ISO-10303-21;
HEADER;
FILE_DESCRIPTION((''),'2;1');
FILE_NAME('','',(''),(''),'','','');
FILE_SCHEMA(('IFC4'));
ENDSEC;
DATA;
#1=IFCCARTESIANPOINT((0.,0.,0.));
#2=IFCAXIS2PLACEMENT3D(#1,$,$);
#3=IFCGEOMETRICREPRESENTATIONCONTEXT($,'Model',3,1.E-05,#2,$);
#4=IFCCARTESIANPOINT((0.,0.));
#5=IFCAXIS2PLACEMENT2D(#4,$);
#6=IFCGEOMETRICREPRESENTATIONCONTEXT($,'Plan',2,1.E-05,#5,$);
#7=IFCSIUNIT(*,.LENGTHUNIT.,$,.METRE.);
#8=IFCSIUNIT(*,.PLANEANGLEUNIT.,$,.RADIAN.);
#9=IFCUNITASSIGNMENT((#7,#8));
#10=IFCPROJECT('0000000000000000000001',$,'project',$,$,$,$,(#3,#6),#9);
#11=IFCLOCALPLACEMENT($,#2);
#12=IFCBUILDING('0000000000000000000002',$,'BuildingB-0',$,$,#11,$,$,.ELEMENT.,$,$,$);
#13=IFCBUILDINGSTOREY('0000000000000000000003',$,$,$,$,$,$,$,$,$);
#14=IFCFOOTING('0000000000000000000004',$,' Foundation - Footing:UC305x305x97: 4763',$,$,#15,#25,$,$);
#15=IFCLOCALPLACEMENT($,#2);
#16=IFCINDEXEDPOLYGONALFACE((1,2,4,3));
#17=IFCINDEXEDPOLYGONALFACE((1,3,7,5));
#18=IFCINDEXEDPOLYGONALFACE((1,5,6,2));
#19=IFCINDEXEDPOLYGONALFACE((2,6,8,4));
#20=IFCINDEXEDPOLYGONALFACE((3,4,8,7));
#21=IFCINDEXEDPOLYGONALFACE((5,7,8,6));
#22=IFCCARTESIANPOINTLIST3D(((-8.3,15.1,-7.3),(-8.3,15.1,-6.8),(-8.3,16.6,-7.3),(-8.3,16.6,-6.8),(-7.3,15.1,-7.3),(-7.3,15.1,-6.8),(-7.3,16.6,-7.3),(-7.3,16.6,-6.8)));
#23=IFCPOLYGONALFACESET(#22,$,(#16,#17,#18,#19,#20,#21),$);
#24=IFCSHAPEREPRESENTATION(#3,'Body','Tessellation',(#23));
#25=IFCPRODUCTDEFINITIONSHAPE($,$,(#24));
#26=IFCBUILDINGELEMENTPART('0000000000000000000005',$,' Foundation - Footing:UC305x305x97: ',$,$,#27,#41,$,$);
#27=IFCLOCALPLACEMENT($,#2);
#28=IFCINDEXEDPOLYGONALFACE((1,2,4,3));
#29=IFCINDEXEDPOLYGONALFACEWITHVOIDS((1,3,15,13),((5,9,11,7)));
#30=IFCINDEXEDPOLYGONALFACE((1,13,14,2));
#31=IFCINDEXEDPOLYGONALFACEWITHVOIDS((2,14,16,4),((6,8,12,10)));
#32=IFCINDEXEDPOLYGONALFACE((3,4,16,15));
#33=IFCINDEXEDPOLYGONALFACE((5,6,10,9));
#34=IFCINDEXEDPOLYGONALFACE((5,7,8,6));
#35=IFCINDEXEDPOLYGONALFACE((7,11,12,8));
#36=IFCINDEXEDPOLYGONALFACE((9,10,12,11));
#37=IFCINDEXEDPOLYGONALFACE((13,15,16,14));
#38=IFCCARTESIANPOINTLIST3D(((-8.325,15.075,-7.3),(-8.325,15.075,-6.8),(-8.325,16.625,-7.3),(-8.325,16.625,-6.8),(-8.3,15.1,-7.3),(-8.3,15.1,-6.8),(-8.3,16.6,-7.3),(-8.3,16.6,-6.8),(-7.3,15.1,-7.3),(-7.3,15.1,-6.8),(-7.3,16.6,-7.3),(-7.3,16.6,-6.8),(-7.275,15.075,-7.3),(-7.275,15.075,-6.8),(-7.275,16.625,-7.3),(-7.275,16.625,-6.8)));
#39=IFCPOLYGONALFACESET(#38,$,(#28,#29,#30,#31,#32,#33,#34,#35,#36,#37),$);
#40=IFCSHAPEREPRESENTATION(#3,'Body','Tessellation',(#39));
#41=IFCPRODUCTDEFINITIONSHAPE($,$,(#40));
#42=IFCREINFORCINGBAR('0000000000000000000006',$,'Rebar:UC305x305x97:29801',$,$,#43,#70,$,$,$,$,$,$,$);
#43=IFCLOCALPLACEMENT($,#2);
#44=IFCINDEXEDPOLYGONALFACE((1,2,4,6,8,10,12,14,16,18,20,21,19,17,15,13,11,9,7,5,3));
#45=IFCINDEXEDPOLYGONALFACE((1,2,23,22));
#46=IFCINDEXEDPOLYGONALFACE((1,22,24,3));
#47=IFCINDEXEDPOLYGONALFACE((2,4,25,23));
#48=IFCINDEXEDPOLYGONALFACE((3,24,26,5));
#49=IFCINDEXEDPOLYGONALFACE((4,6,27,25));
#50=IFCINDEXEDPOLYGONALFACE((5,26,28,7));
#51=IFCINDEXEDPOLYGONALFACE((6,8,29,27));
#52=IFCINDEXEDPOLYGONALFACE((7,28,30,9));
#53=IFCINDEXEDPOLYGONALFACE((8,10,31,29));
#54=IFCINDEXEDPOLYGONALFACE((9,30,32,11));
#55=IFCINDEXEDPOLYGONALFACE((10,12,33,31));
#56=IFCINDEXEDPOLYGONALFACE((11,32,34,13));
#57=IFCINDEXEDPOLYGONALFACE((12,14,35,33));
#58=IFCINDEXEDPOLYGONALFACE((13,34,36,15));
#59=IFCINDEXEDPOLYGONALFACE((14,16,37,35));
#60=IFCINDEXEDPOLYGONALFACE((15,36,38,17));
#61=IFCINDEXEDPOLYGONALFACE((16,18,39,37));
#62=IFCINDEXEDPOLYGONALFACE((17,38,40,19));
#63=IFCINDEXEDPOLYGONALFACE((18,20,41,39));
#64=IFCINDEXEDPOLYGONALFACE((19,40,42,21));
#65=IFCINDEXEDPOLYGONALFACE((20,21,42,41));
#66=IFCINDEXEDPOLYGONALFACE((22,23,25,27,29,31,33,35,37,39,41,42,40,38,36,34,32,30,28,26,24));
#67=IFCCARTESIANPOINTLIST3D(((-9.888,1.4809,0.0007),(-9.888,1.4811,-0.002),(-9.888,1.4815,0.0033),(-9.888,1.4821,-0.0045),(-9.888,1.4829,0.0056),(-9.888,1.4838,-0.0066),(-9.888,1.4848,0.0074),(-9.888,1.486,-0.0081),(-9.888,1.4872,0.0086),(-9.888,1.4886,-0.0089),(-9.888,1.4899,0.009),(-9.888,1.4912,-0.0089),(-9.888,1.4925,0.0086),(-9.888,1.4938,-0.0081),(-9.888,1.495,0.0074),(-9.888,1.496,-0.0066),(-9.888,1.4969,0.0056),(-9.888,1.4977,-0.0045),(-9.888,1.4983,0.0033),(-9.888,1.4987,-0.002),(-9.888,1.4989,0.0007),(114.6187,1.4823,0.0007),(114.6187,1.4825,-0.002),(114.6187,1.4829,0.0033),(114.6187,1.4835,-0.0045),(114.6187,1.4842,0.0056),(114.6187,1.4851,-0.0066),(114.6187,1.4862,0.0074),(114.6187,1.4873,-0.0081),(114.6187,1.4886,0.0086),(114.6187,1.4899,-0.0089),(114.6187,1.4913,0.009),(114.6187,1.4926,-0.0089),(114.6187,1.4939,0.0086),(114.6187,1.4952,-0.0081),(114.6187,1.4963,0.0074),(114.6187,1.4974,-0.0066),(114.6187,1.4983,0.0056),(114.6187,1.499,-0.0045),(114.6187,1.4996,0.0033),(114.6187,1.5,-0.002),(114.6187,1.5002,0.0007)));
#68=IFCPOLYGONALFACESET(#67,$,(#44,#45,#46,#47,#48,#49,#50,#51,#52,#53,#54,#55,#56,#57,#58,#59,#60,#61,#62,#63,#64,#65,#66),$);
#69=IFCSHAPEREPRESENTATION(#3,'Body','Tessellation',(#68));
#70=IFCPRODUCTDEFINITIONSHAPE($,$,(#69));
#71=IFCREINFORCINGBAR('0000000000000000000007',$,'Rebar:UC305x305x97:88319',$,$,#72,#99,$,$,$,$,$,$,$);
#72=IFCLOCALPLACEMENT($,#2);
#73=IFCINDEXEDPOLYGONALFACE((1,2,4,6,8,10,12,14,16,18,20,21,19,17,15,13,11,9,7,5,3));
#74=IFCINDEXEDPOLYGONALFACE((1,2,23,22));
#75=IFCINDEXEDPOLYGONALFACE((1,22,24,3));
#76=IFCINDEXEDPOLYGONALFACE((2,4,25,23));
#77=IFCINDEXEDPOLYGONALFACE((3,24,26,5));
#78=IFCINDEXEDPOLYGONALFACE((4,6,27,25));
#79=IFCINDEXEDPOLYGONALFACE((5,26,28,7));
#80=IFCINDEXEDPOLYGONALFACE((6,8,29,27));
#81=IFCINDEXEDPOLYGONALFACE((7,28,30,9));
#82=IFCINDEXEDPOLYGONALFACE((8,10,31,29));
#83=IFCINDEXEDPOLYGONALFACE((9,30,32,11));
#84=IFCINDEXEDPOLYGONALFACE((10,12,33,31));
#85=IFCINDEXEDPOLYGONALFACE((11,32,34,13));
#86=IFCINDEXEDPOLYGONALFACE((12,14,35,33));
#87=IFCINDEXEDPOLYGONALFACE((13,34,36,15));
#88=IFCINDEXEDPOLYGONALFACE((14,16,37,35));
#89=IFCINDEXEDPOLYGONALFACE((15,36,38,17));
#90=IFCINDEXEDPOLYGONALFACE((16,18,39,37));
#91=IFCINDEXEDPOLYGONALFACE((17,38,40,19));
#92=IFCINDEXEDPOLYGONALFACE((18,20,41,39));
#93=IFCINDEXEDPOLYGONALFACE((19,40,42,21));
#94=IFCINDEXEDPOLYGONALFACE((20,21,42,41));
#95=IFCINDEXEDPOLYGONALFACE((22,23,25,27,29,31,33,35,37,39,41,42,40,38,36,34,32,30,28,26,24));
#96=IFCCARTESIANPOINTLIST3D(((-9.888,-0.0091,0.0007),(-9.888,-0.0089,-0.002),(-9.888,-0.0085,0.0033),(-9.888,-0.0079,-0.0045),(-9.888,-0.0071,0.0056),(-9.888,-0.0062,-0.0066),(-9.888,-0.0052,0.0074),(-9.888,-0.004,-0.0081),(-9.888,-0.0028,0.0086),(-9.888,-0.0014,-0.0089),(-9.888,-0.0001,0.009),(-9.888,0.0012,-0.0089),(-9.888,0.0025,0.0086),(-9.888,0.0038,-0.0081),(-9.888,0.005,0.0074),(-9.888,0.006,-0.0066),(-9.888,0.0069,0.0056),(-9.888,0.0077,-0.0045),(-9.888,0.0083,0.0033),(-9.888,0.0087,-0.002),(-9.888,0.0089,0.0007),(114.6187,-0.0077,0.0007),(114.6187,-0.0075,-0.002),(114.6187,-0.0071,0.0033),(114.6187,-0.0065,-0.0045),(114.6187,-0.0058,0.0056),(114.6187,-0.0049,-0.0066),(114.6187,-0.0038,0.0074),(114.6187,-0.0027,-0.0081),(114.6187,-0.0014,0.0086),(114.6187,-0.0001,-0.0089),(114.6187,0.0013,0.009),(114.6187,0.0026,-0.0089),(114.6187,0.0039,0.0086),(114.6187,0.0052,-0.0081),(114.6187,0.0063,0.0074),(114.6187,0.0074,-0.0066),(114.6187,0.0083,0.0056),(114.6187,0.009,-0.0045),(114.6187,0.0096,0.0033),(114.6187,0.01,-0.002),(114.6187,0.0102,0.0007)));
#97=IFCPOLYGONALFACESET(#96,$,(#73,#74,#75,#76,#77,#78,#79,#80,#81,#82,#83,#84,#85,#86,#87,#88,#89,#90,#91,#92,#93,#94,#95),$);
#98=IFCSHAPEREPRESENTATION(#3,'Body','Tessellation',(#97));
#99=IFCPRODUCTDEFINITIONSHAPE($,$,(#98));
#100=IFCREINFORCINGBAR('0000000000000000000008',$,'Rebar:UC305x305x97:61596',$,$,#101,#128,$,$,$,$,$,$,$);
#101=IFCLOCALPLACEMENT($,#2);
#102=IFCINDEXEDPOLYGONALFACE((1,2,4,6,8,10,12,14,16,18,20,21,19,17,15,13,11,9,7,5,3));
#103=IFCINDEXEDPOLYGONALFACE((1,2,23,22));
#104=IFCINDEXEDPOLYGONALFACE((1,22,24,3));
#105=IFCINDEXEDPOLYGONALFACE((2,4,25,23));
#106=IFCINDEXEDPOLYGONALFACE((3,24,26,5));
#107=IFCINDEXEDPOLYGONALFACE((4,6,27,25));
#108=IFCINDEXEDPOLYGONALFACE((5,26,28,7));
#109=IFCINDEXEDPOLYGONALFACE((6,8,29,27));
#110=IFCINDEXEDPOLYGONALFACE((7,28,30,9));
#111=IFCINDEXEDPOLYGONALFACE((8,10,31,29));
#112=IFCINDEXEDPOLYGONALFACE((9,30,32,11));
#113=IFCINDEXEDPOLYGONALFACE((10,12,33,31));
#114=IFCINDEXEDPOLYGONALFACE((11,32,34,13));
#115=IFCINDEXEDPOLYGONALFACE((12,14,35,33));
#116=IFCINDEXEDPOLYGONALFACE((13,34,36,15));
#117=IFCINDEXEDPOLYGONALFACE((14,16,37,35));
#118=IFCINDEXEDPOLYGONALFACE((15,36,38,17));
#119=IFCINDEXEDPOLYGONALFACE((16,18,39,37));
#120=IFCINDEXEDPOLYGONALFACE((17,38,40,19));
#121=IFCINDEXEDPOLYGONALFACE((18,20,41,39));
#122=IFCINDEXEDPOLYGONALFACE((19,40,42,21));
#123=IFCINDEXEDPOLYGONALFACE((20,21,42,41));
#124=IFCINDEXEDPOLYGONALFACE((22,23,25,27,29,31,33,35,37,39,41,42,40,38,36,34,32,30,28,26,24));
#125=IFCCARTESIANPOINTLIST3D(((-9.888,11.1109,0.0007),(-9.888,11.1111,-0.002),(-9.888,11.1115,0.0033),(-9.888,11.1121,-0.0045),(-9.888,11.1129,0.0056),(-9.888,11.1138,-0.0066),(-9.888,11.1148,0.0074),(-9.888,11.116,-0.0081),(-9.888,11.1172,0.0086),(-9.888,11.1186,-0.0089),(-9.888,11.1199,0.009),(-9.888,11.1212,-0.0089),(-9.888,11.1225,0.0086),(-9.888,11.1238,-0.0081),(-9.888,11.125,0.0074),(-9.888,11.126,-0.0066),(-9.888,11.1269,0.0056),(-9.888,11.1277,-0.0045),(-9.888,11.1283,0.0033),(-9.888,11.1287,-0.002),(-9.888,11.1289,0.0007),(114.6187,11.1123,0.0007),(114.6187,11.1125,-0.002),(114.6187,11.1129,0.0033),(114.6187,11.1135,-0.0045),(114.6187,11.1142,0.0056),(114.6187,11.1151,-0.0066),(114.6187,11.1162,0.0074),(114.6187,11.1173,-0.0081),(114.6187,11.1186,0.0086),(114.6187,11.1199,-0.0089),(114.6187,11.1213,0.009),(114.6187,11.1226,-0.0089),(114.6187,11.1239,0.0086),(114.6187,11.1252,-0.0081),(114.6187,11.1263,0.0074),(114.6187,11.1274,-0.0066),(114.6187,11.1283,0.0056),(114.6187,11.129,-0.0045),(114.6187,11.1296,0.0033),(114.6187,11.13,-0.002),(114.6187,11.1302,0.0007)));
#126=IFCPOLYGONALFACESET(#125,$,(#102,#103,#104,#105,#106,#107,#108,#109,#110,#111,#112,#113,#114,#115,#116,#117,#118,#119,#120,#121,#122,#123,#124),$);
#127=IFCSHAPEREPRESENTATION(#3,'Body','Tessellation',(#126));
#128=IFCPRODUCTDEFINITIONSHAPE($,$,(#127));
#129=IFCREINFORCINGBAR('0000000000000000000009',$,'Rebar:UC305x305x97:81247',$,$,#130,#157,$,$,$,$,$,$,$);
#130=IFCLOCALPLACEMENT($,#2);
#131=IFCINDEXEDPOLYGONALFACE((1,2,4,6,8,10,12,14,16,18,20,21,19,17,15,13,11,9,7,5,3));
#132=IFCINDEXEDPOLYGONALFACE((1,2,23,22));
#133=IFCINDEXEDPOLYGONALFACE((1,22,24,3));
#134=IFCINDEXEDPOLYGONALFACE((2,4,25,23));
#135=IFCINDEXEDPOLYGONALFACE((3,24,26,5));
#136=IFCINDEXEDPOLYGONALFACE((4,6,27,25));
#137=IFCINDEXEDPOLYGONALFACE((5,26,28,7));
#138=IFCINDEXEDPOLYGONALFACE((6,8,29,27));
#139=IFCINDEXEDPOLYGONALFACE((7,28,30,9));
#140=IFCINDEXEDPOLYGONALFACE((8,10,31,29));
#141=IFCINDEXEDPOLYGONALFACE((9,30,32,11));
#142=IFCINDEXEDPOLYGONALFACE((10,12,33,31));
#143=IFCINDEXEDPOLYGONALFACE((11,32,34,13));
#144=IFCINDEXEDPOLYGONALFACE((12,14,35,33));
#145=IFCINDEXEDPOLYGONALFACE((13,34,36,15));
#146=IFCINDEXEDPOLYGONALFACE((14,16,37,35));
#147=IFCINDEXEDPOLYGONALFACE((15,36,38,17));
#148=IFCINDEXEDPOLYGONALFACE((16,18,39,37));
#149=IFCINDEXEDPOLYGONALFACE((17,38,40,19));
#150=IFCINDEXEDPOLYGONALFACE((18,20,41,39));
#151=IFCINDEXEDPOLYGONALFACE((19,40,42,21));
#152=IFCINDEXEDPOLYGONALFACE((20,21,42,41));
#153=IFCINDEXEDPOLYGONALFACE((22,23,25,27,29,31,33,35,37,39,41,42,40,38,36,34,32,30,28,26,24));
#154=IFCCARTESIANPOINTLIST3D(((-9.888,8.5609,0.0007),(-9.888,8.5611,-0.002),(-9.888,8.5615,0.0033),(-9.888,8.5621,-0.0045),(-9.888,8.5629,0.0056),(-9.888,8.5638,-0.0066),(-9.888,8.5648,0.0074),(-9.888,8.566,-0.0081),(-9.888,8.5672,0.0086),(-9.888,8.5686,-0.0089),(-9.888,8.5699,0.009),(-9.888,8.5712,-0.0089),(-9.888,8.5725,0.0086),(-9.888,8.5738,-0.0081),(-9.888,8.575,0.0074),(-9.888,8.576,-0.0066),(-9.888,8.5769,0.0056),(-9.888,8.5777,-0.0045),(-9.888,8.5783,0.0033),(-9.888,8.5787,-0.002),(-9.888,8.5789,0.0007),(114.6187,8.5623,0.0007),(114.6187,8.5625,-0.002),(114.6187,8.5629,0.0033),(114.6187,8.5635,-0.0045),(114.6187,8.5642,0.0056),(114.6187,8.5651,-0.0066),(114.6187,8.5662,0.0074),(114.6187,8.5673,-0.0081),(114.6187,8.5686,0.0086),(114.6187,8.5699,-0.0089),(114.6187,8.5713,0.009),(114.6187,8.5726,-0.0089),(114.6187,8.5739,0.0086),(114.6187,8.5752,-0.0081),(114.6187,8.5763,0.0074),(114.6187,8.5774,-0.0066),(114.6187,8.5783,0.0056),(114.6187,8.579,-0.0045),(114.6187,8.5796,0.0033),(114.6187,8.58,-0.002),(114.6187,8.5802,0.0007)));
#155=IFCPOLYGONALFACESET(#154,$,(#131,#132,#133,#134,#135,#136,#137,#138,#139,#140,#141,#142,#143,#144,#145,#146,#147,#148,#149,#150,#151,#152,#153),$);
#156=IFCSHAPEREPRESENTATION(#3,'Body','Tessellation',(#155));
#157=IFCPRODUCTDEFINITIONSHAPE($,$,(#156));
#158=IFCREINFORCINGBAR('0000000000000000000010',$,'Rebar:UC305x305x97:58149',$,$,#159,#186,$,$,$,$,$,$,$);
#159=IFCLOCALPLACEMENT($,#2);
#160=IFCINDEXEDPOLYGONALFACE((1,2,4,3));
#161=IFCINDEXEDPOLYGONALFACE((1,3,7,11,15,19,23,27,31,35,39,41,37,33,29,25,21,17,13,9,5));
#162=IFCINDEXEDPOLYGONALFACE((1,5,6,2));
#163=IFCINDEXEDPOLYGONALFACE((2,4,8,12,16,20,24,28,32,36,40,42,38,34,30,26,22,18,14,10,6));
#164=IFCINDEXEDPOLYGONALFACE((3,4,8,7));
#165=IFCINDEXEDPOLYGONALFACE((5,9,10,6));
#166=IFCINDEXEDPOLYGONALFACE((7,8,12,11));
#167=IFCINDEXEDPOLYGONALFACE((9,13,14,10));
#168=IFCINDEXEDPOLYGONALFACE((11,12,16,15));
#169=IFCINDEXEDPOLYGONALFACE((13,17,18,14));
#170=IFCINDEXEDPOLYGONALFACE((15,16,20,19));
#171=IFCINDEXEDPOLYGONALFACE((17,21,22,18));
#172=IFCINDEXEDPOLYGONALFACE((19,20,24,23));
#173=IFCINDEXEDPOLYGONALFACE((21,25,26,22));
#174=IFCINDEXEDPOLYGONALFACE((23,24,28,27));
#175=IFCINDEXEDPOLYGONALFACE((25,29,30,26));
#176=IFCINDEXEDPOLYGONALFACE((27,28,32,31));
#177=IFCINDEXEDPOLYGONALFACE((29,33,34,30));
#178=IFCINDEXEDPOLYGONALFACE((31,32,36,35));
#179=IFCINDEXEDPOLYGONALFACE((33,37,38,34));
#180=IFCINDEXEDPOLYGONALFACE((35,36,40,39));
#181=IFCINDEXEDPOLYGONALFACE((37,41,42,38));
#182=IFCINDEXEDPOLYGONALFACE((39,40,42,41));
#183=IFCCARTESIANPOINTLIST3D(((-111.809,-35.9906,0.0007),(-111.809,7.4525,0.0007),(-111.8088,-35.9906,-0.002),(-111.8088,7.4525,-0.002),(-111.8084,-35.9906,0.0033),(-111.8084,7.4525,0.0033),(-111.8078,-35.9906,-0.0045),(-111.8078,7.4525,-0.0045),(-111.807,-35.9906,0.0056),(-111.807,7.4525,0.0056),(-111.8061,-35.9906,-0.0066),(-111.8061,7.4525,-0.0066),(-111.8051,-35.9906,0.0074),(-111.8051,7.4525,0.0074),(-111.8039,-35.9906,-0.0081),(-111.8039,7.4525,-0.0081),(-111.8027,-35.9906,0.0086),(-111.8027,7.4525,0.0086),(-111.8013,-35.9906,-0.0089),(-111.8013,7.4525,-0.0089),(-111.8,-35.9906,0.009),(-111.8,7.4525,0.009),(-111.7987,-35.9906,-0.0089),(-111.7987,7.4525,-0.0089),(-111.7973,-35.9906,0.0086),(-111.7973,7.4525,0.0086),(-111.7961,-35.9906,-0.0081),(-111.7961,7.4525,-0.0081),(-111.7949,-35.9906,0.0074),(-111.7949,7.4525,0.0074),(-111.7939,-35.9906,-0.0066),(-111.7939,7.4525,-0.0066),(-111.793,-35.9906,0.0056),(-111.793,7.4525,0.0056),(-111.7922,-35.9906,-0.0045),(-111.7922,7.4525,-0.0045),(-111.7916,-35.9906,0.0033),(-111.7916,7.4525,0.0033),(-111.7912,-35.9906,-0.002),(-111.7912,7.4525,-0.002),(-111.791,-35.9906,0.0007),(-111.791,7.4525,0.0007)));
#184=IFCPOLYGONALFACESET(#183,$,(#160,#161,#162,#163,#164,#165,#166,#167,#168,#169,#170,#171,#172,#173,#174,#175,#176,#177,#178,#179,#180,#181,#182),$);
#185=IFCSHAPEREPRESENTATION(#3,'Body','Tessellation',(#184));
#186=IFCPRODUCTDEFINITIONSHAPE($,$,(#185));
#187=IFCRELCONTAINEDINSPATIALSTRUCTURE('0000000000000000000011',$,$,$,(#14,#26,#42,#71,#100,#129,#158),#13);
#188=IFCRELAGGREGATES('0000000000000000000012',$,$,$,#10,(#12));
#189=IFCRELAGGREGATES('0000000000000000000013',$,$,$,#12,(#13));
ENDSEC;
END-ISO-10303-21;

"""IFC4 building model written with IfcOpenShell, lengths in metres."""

from ifc_helpers import new_model, entity, si_unit, origin, origin_2d, place, context, project, spatial, polyline, outline, extrude, element, save


model = new_model("IFC4")

# Units and contexts
model_context = context("Model", 3, precision=1e-05, world=origin())
plan_context = context("Plan", 2, precision=1e-05, world=origin_2d())
ifc_project = project(units=[si_unit("LENGTHUNIT", "METRE"), si_unit("PLANEANGLEUNIT", "RADIAN")], contexts=[model_context, plan_context])

# Building, storey
building_placement = place(None, origin())
building = spatial("IfcBuilding", under=ifc_project, at=building_placement, Name="BuildingB-0", CompositionType="ELEMENT")
storey = spatial("IfcBuildingStorey", under=building)

# Footing
element("IfcFooting", 1, inside=storey, Name=" Foundation - Footing:UC305x305x97: 4763", context=model_context, shape_type="SweptSolid", body=[
    extrude(outline(polyline([(-7.3, 16.6, -7.3), (-8.3, 16.6, -7.3), (-8.3, 15.1, -7.3), (-7.3, 15.1, -7.3), (-7.3, 16.6, -7.3)])), None, (0.0, 0.0, 1.0), 0.5),
])

# Building element part, opening
building_element_part = element("IfcBuildingElementPart", 2, inside=storey, Name=" Foundation - Footing:UC305x305x97: ", context=model_context, shape_type="SweptSolid", body=[
    extrude(outline(polyline([(-7.275, 16.625, -7.3), (-8.325, 16.625, -7.3), (-8.325, 15.075, -7.3), (-7.275, 15.075, -7.3), (-7.275, 16.625, -7.3)])), None, (0.0, 0.0, 1.0), 0.5),
])
element("IfcOpeningElement", 3, inside=storey, cuts=building_element_part, context=model_context, shape_type="SweptSolid", body=[
    extrude(outline(polyline([(-7.3, 16.6, -7.3), (-8.3, 16.6, -7.3), (-8.3, 15.1, -7.3), (-7.3, 15.1, -7.3), (-7.3, 16.6, -7.3)])), None, (0.0, 0.0, 1.0), 0.5),
])

# Reinforcing bars
element("IfcReinforcingBar", 4, inside=storey, Name="Rebar:UC305x305x97:29801", context=model_context, shape_type="SweptSolid", body=[
    entity("IfcSurfaceCurveSweptAreaSolid", entity("IfcCircleProfileDef", "AREA", None, None, 0.009), None, entity("IfcPolyline", [entity("IfcCartesianPoint", [-9.888, 1.4899, 0.0]), entity("IfcCartesianPoint", [114.6187, 1.4913, 0.0])]), None, None, entity("IfcPlane", entity("IfcAxis2Placement3D", entity("IfcCartesianPoint", [-9.888, 1.4899, 0.0]), entity("IfcDirection", [0.0, 0.0, 1.0]), entity("IfcDirection", [1.0, 0.0, 0.0])))),
])
element("IfcReinforcingBar", 5, inside=storey, Name="Rebar:UC305x305x97:88319", context=model_context, shape_type="SweptSolid", body=[
    entity("IfcSurfaceCurveSweptAreaSolid", entity("IfcCircleProfileDef", "AREA", None, None, 0.009), None, entity("IfcPolyline", [entity("IfcCartesianPoint", [-9.888, -0.0001, 0.0]), entity("IfcCartesianPoint", [114.6187, 0.0013, 0.0])]), None, None, entity("IfcPlane", entity("IfcAxis2Placement3D", entity("IfcCartesianPoint", [-9.888, -0.0001, 0.0]), entity("IfcDirection", [0.0, 0.0, 1.0]), entity("IfcDirection", [1.0, 0.0, 0.0])))),
])
element("IfcReinforcingBar", 6, inside=storey, Name="Rebar:UC305x305x97:61596", context=model_context, shape_type="SweptSolid", body=[
    entity("IfcSurfaceCurveSweptAreaSolid", entity("IfcCircleProfileDef", "AREA", None, None, 0.009), None, entity("IfcPolyline", [entity("IfcCartesianPoint", [-9.888, 11.1199, 0.0]), entity("IfcCartesianPoint", [114.6187, 11.1213, 0.0])]), None, None, entity("IfcPlane", entity("IfcAxis2Placement3D", entity("IfcCartesianPoint", [-9.888, 11.1199, 0.0]), entity("IfcDirection", [0.0, 0.0, 1.0]), entity("IfcDirection", [1.0, 0.0, 0.0])))),
])
element("IfcReinforcingBar", 7, inside=storey, Name="Rebar:UC305x305x97:81247", context=model_context, shape_type="SweptSolid", body=[
    entity("IfcSurfaceCurveSweptAreaSolid", entity("IfcCircleProfileDef", "AREA", None, None, 0.009), None, entity("IfcPolyline", [entity("IfcCartesianPoint", [-9.888, 8.5699, 0.0]), entity("IfcCartesianPoint", [114.6187, 8.5713, 0.0])]), None, None, entity("IfcPlane", entity("IfcAxis2Placement3D", entity("IfcCartesianPoint", [-9.888, 8.5699, 0.0]), entity("IfcDirection", [0.0, 0.0, 1.0]), entity("IfcDirection", [1.0, 0.0, 0.0])))),
])
element("IfcReinforcingBar", 8, inside=storey, Name="Rebar:UC305x305x97:58149", context=model_context, shape_type="SweptSolid", body=[
    entity("IfcSurfaceCurveSweptAreaSolid", entity("IfcCircleProfileDef", "AREA", None, None, 0.009), None, entity("IfcPolyline", [entity("IfcCartesianPoint", [111.8, 35.9906, 0.0]), entity("IfcCartesianPoint", [111.8, -7.4525, 0.0])]), None, None, entity("IfcPlane", entity("IfcAxis2Placement3D", entity("IfcCartesianPoint", [111.8, 35.9906, 0.0]), entity("IfcDirection", [0.0, 0.0, 1.0]), entity("IfcDirection", [1.0, 0.0, 0.0])))),
])

save(model, "model.ifc")
